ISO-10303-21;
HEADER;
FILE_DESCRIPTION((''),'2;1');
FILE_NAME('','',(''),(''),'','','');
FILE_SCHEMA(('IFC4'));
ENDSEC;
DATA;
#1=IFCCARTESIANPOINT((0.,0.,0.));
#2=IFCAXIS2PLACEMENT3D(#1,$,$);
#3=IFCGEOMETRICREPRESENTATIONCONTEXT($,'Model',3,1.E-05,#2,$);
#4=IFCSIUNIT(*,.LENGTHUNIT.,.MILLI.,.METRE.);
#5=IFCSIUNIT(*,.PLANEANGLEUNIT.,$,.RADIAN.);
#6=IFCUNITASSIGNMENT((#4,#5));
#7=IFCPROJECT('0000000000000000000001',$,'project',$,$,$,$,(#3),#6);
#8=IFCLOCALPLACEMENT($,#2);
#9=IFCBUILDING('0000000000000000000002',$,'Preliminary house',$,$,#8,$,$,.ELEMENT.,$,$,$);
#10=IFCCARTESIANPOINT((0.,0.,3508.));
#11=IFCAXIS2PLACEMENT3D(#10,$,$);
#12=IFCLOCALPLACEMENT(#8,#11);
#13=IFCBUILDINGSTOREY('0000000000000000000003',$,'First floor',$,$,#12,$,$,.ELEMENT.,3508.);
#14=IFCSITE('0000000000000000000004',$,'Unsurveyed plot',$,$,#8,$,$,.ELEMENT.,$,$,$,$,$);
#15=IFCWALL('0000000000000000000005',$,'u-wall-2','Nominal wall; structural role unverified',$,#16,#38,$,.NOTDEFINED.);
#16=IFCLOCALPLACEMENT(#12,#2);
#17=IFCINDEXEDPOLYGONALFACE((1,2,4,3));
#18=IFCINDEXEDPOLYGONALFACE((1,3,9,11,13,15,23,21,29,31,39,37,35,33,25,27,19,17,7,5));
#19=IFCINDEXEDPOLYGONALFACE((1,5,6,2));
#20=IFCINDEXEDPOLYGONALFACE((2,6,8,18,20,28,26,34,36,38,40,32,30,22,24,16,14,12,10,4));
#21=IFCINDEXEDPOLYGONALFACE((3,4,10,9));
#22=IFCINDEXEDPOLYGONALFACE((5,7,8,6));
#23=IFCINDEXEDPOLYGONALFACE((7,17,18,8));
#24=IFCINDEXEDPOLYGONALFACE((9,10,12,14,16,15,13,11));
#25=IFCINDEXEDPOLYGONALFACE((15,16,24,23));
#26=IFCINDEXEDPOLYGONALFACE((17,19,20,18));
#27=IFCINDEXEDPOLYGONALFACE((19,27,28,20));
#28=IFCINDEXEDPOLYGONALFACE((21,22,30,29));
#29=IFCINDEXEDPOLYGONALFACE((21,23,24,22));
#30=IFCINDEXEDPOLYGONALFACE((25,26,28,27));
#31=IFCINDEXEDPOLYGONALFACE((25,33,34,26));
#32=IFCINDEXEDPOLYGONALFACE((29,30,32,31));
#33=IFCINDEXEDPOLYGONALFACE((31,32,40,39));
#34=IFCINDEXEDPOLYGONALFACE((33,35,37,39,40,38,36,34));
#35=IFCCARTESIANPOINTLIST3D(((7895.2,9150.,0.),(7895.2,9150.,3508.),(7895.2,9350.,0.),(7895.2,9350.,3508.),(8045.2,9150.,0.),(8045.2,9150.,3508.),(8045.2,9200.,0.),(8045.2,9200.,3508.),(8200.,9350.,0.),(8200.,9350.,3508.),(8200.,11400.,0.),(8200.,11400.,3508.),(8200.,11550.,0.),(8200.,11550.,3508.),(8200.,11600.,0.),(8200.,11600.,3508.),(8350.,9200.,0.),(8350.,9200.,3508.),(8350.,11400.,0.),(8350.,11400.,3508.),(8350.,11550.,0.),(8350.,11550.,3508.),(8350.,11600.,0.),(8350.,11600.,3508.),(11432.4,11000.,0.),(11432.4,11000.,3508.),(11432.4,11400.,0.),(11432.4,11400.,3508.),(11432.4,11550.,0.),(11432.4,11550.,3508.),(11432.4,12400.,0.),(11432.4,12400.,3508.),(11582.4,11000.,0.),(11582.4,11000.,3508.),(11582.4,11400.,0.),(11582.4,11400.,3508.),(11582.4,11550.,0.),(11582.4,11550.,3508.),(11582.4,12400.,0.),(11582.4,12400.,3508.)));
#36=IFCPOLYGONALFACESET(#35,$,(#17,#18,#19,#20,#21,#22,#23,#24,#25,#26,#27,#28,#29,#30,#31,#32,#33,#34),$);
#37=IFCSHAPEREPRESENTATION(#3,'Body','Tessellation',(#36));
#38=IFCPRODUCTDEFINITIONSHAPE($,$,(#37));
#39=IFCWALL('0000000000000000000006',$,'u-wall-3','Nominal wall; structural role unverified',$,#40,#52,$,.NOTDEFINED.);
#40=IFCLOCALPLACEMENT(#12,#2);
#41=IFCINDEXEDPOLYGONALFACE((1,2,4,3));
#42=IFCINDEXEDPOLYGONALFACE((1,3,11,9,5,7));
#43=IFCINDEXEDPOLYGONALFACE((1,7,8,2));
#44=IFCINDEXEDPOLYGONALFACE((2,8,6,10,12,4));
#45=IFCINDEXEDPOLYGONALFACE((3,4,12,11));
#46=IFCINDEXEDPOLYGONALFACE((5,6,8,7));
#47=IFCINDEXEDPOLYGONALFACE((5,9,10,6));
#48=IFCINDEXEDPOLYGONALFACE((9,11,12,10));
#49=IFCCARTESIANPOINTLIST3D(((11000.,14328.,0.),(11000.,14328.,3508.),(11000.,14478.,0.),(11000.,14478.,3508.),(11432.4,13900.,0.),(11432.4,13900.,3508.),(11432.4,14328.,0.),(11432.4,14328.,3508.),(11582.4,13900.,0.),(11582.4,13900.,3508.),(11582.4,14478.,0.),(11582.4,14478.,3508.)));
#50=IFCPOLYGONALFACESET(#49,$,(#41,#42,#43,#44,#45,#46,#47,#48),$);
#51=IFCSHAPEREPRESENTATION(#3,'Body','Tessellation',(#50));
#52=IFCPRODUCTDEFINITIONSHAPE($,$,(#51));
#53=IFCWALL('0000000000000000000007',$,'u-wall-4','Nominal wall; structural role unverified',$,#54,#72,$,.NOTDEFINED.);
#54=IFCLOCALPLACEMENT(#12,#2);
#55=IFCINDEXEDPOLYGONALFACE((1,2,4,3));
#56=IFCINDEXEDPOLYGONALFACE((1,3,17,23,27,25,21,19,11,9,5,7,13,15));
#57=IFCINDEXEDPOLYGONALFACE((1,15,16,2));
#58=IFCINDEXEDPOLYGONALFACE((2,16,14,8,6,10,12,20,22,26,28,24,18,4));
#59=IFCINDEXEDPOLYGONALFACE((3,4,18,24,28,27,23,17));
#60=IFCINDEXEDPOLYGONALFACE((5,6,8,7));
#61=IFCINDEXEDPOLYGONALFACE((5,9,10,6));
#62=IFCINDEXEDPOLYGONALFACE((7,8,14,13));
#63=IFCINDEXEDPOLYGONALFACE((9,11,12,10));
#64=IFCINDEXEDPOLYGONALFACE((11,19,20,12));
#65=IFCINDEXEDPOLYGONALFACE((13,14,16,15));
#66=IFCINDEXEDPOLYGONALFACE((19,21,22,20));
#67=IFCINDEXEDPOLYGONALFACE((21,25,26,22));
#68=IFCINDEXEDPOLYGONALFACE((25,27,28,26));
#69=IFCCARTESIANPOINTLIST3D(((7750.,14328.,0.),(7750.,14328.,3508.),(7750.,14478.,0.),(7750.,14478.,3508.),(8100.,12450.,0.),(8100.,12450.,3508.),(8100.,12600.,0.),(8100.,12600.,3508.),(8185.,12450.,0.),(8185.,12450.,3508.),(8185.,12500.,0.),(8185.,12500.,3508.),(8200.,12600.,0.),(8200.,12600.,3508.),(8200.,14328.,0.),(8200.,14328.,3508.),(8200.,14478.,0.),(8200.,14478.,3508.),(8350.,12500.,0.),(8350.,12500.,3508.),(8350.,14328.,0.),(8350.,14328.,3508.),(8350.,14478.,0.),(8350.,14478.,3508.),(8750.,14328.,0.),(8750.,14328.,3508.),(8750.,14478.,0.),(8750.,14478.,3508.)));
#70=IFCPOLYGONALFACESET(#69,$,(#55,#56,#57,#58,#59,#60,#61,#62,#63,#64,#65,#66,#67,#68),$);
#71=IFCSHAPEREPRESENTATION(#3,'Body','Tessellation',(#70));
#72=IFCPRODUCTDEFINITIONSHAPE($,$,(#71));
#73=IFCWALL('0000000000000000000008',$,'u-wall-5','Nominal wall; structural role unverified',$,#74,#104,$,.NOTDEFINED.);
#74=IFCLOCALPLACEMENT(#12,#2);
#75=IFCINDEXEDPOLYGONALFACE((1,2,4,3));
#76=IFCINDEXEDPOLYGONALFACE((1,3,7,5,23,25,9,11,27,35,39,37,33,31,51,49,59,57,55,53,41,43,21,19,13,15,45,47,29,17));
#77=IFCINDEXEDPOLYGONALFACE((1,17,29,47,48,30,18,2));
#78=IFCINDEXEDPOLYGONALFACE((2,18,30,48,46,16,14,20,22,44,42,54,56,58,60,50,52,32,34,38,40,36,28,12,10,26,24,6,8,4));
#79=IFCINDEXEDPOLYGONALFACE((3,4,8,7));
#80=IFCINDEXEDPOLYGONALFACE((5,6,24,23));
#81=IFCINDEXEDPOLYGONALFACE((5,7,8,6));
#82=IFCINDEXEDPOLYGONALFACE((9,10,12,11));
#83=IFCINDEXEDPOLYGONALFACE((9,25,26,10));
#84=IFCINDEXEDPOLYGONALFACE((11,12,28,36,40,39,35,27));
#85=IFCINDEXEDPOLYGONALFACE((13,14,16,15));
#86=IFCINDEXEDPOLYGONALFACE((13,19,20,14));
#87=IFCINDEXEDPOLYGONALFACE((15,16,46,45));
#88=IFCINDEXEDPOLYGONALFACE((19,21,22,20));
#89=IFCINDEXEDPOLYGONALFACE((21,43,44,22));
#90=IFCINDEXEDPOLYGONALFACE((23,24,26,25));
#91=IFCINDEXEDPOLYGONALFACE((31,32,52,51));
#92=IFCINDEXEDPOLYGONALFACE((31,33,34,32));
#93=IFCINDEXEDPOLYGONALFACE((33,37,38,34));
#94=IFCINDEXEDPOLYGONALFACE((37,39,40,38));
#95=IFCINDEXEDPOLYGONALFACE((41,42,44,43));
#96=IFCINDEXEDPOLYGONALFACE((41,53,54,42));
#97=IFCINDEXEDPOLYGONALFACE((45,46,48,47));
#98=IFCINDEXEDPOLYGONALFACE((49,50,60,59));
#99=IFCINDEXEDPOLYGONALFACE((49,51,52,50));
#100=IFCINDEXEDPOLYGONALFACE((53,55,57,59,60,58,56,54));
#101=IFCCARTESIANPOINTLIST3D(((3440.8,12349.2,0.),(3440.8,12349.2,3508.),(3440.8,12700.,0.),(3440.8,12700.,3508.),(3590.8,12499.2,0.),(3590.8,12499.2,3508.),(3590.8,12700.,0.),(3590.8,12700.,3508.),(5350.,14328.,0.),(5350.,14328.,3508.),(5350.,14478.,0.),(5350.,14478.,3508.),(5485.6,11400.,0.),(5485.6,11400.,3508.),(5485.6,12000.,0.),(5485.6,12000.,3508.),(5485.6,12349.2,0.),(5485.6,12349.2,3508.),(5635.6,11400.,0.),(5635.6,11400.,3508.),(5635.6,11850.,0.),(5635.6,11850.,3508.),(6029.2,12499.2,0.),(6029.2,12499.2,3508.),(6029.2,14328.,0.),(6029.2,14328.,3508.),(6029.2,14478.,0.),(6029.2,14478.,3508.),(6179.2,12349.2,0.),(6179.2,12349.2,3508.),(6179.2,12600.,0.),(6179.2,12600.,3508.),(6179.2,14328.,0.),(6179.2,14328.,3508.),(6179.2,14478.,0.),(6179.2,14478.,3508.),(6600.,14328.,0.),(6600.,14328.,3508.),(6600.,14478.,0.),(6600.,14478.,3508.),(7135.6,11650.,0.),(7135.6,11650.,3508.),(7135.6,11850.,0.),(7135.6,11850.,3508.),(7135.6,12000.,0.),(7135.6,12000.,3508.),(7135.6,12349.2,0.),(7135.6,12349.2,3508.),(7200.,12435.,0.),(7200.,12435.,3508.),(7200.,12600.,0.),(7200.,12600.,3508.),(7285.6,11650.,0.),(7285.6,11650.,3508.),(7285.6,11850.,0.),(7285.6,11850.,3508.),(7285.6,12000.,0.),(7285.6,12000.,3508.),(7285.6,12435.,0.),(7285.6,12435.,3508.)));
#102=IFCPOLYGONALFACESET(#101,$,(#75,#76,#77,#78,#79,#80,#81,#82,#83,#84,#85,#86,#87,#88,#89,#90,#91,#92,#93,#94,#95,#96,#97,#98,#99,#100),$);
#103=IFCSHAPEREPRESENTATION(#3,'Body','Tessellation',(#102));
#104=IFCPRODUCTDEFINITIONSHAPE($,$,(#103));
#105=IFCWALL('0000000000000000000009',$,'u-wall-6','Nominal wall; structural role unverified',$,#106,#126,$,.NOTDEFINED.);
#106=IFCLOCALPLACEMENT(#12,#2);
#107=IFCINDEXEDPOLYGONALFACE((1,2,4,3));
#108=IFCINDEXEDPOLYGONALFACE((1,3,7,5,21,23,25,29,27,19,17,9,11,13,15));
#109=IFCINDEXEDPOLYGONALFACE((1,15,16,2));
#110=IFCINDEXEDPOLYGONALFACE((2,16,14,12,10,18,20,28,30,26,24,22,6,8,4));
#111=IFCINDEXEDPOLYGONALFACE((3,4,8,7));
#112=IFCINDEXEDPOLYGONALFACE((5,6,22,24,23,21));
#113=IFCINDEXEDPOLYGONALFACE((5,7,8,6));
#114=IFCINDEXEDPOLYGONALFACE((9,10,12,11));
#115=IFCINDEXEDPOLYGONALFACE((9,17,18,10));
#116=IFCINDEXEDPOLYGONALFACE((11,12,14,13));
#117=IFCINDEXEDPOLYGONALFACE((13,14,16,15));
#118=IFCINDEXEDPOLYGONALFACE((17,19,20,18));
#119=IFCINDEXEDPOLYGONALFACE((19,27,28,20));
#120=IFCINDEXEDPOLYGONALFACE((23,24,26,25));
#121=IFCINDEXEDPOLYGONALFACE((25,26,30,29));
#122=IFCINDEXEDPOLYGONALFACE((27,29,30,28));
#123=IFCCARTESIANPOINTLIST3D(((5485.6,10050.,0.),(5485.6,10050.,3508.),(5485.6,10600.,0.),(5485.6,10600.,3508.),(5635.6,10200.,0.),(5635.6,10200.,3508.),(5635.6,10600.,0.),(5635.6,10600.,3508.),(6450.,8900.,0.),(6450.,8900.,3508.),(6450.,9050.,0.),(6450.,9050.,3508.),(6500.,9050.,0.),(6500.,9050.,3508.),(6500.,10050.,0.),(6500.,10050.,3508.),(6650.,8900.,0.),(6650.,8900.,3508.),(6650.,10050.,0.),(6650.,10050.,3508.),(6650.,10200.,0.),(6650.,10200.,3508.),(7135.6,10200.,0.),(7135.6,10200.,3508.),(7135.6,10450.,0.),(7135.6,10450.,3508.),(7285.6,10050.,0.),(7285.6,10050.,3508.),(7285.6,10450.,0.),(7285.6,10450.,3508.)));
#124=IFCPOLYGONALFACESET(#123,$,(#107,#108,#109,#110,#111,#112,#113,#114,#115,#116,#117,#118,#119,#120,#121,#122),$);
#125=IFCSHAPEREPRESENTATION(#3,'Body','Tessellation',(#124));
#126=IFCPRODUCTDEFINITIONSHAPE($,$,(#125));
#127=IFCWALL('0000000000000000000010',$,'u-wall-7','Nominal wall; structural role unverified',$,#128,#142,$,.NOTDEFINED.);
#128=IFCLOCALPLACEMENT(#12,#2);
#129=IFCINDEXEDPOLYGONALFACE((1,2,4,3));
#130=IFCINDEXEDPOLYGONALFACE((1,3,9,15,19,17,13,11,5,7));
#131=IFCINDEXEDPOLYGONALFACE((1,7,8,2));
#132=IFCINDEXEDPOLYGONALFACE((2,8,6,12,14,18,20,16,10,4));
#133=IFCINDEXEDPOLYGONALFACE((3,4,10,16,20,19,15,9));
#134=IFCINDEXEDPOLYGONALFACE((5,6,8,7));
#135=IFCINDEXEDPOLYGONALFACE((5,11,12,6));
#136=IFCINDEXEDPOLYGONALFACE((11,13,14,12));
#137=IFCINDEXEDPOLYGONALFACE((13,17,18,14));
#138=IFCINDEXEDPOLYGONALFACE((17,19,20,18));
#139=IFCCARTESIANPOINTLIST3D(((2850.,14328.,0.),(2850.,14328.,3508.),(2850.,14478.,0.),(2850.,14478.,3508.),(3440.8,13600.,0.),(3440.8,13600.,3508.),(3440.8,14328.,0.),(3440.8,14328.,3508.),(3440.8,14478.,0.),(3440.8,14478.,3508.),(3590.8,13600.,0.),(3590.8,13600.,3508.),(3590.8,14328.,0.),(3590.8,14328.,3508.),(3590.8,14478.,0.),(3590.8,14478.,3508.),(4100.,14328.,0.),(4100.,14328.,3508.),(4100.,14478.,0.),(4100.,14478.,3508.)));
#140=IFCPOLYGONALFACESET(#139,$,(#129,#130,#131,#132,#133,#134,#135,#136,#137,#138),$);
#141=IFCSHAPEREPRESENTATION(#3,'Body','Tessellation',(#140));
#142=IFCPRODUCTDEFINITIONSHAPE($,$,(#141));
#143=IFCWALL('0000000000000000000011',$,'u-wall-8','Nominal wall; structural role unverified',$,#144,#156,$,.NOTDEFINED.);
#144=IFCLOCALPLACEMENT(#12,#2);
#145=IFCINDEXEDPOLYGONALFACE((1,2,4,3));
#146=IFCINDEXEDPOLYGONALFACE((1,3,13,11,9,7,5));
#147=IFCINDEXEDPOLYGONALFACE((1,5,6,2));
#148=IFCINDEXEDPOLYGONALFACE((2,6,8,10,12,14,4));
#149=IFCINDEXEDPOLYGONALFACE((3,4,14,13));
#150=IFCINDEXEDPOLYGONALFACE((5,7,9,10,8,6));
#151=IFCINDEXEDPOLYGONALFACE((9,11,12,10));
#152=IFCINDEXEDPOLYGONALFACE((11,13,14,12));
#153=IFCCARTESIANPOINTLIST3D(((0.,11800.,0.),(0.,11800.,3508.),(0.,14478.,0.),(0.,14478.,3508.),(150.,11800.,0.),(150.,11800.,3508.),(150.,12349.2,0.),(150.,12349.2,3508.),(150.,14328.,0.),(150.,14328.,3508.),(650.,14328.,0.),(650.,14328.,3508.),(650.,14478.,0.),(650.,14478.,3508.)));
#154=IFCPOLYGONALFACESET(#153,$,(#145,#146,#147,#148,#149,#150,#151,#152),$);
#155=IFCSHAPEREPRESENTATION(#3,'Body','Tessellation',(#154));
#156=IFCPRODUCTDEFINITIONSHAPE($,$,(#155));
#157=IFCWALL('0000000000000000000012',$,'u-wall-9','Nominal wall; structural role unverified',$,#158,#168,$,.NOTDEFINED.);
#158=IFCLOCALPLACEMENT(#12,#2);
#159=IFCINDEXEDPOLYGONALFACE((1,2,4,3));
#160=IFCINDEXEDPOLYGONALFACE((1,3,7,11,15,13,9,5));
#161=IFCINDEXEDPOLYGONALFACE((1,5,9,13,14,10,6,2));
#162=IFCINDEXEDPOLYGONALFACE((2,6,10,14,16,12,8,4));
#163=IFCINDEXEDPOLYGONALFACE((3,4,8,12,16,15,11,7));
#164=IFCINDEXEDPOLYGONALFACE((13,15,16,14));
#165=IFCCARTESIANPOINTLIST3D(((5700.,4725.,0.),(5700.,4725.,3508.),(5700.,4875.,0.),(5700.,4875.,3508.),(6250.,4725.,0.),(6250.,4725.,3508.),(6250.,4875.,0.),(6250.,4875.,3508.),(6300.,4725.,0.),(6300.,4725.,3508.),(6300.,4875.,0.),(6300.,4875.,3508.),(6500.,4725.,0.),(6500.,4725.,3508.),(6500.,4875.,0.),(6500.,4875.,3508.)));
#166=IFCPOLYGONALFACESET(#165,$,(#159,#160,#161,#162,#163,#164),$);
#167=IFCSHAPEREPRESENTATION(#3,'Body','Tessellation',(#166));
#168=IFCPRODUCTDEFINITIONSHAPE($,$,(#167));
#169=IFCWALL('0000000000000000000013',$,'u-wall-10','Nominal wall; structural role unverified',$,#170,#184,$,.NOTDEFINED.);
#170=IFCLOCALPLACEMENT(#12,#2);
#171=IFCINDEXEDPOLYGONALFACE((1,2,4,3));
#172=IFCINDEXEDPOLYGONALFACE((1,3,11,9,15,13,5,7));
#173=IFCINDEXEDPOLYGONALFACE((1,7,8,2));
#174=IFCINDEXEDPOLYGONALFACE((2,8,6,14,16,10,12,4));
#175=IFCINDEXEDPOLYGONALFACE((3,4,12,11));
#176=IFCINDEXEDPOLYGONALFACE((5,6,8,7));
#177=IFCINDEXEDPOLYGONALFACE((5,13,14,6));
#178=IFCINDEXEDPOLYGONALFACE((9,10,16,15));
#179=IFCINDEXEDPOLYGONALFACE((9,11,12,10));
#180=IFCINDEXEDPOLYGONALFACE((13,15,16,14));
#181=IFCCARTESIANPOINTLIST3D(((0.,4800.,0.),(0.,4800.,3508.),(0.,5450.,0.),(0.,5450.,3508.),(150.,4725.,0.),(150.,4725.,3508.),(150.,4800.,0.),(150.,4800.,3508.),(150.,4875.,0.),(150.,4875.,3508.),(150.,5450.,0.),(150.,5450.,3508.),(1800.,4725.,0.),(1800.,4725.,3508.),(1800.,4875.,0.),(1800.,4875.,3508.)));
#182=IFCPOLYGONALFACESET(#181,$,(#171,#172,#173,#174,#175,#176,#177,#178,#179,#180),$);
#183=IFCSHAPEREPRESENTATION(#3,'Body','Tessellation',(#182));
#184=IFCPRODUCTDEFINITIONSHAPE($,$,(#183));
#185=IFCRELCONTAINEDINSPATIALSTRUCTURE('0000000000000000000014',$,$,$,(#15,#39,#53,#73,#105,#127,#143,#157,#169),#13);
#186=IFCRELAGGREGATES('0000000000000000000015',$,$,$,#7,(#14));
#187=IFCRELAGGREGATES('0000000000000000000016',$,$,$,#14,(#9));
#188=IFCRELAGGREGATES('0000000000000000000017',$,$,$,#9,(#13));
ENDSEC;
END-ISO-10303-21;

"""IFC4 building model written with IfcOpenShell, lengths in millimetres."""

from ifc_helpers import new_model, si_unit, frame, origin, place, context, project, spatial, polyline, outline, extrude, element, save


model = new_model("IFC4")

# Units and contexts
model_context = context("Model", 3, precision=1e-05, world=origin())
ifc_project = project(units=[si_unit("LENGTHUNIT", "METRE", prefix="MILLI"), si_unit("PLANEANGLEUNIT", "RADIAN")], contexts=[model_context])

# Site, building, storey
placement_1 = place(None, origin())
site = spatial("IfcSite", under=ifc_project, at=placement_1, Name="Unsurveyed plot", CompositionType="ELEMENT")
building = spatial("IfcBuilding", under=site, at=placement_1, Name="Preliminary house", CompositionType="ELEMENT")
placement_2 = place(placement_1, frame((0.0, 0.0, 3508.0)))
storey = spatial("IfcBuildingStorey", under=building, at=placement_2, Name="First floor", CompositionType="ELEMENT", Elevation=3508.0)

# Walls
element("IfcWall", 1, at=placement_2, inside=storey, Name="u-wall-2", Description="Nominal wall; structural role unverified", PredefinedType="NOTDEFINED", context=model_context, shape_type="SweptSolid", body=[
    extrude(outline(polyline([(8200.0, 9350.0), (8200.0, 11400.0), (8200.0, 11550.0), (8200.0, 11600.0), (8350.0, 11600.0), (8350.0, 11550.0), (11432.4, 11550.0), (11432.4, 12400.0), (11582.4, 12400.0), (11582.4, 11550.0), (11582.4, 11400.0), (11582.4, 11000.0), (11432.4, 11000.0), (11432.4, 11400.0), (8350.0, 11400.0), (8350.0, 9200.0), (8045.2, 9200.0), (8045.2, 9150.0), (7895.2, 9150.0), (7895.2, 9350.0), (8200.0, 9350.0)])), origin(), (0.0, 0.0, 1.0), 3508.0),
])
element("IfcWall", 2, at=placement_2, inside=storey, Name="u-wall-3", Description="Nominal wall; structural role unverified", PredefinedType="NOTDEFINED", context=model_context, shape_type="SweptSolid", body=[
    extrude(outline(polyline([(11000.0, 14478.0), (11582.4, 14478.0), (11582.4, 13900.0), (11432.4, 13900.0), (11432.4, 14328.0), (11000.0, 14328.0), (11000.0, 14478.0)])), origin(), (0.0, 0.0, 1.0), 3508.0),
])
element("IfcWall", 3, at=placement_2, inside=storey, Name="u-wall-4", Description="Nominal wall; structural role unverified", PredefinedType="NOTDEFINED", context=model_context, shape_type="SweptSolid", body=[
    extrude(outline(polyline([(7750.0, 14478.0), (8200.0, 14478.0), (8350.0, 14478.0), (8750.0, 14478.0), (8750.0, 14328.0), (8350.0, 14328.0), (8350.0, 12500.0), (8185.0, 12500.0), (8185.0, 12450.0), (8100.0, 12450.0), (8100.0, 12600.0), (8200.0, 12600.0), (8200.0, 14328.0), (7750.0, 14328.0), (7750.0, 14478.0)])), origin(), (0.0, 0.0, 1.0), 3508.0),
])
element("IfcWall", 4, at=placement_2, inside=storey, Name="u-wall-5", Description="Nominal wall; structural role unverified", PredefinedType="NOTDEFINED", context=model_context, shape_type="SweptSolid", body=[
    extrude(outline(polyline([(7285.6, 12000.0), (7285.6, 11850.0), (7285.6, 11650.0), (7135.6, 11650.0), (7135.6, 11850.0), (5635.6, 11850.0), (5635.6, 11400.0), (5485.6, 11400.0), (5485.6, 12000.0), (7135.6, 12000.0), (7135.6, 12349.2), (6179.2, 12349.2), (5485.6, 12349.2), (3440.8, 12349.2), (3440.8, 12700.0), (3590.8, 12700.0), (3590.8, 12499.2), (6029.2, 12499.2), (6029.2, 14328.0), (5350.0, 14328.0), (5350.0, 14478.0), (6029.2, 14478.0), (6179.2, 14478.0), (6600.0, 14478.0), (6600.0, 14328.0), (6179.2, 14328.0), (6179.2, 12600.0), (7200.0, 12600.0), (7200.0, 12435.0), (7285.6, 12435.0), (7285.6, 12000.0)])), origin(), (0.0, 0.0, 1.0), 3508.0),
])
element("IfcWall", 5, at=placement_2, inside=storey, Name="u-wall-6", Description="Nominal wall; structural role unverified", PredefinedType="NOTDEFINED", context=model_context, shape_type="SweptSolid", body=[
    extrude(outline(polyline([(7135.6, 10200.0), (7135.6, 10450.0), (7285.6, 10450.0), (7285.6, 10050.0), (6650.0, 10050.0), (6650.0, 8900.0), (6450.0, 8900.0), (6450.0, 9050.0), (6500.0, 9050.0), (6500.0, 10050.0), (5485.6, 10050.0), (5485.6, 10600.0), (5635.6, 10600.0), (5635.6, 10200.0), (6650.0, 10200.0), (7135.6, 10200.0)])), origin(), (0.0, 0.0, 1.0), 3508.0),
])
element("IfcWall", 6, at=placement_2, inside=storey, Name="u-wall-7", Description="Nominal wall; structural role unverified", PredefinedType="NOTDEFINED", context=model_context, shape_type="SweptSolid", body=[
    extrude(outline(polyline([(2850.0, 14328.0), (2850.0, 14478.0), (3440.8, 14478.0), (3590.8, 14478.0), (4100.0, 14478.0), (4100.0, 14328.0), (3590.8, 14328.0), (3590.8, 13600.0), (3440.8, 13600.0), (3440.8, 14328.0), (2850.0, 14328.0)])), origin(), (0.0, 0.0, 1.0), 3508.0),
])
element("IfcWall", 7, at=placement_2, inside=storey, Name="u-wall-8", Description="Nominal wall; structural role unverified", PredefinedType="NOTDEFINED", context=model_context, shape_type="SweptSolid", body=[
    extrude(outline(polyline([(0.0, 14478.0), (650.0, 14478.0), (650.0, 14328.0), (150.0, 14328.0), (150.0, 12349.2), (150.0, 11800.0), (0.0, 11800.0), (0.0, 14478.0)])), origin(), (0.0, 0.0, 1.0), 3508.0),
])
element("IfcWall", 8, at=placement_2, inside=storey, Name="u-wall-9", Description="Nominal wall; structural role unverified", PredefinedType="NOTDEFINED", context=model_context, shape_type="SweptSolid", body=[
    extrude(outline(polyline([(6300.0, 4725.0), (6250.0, 4725.0), (5700.0, 4725.0), (5700.0, 4875.0), (6250.0, 4875.0), (6300.0, 4875.0), (6500.0, 4875.0), (6500.0, 4725.0), (6300.0, 4725.0)])), origin(), (0.0, 0.0, 1.0), 3508.0),
])
element("IfcWall", 9, at=placement_2, inside=storey, Name="u-wall-10", Description="Nominal wall; structural role unverified", PredefinedType="NOTDEFINED", context=model_context, shape_type="SweptSolid", body=[
    extrude(outline(polyline([(150.0, 4800.0), (0.0, 4800.0), (0.0, 5450.0), (150.0, 5450.0), (150.0, 4875.0), (1800.0, 4875.0), (1800.0, 4725.0), (150.0, 4725.0), (150.0, 4800.0)])), origin(), (0.0, 0.0, 1.0), 3508.0),
])

save(model, "model.ifc")
